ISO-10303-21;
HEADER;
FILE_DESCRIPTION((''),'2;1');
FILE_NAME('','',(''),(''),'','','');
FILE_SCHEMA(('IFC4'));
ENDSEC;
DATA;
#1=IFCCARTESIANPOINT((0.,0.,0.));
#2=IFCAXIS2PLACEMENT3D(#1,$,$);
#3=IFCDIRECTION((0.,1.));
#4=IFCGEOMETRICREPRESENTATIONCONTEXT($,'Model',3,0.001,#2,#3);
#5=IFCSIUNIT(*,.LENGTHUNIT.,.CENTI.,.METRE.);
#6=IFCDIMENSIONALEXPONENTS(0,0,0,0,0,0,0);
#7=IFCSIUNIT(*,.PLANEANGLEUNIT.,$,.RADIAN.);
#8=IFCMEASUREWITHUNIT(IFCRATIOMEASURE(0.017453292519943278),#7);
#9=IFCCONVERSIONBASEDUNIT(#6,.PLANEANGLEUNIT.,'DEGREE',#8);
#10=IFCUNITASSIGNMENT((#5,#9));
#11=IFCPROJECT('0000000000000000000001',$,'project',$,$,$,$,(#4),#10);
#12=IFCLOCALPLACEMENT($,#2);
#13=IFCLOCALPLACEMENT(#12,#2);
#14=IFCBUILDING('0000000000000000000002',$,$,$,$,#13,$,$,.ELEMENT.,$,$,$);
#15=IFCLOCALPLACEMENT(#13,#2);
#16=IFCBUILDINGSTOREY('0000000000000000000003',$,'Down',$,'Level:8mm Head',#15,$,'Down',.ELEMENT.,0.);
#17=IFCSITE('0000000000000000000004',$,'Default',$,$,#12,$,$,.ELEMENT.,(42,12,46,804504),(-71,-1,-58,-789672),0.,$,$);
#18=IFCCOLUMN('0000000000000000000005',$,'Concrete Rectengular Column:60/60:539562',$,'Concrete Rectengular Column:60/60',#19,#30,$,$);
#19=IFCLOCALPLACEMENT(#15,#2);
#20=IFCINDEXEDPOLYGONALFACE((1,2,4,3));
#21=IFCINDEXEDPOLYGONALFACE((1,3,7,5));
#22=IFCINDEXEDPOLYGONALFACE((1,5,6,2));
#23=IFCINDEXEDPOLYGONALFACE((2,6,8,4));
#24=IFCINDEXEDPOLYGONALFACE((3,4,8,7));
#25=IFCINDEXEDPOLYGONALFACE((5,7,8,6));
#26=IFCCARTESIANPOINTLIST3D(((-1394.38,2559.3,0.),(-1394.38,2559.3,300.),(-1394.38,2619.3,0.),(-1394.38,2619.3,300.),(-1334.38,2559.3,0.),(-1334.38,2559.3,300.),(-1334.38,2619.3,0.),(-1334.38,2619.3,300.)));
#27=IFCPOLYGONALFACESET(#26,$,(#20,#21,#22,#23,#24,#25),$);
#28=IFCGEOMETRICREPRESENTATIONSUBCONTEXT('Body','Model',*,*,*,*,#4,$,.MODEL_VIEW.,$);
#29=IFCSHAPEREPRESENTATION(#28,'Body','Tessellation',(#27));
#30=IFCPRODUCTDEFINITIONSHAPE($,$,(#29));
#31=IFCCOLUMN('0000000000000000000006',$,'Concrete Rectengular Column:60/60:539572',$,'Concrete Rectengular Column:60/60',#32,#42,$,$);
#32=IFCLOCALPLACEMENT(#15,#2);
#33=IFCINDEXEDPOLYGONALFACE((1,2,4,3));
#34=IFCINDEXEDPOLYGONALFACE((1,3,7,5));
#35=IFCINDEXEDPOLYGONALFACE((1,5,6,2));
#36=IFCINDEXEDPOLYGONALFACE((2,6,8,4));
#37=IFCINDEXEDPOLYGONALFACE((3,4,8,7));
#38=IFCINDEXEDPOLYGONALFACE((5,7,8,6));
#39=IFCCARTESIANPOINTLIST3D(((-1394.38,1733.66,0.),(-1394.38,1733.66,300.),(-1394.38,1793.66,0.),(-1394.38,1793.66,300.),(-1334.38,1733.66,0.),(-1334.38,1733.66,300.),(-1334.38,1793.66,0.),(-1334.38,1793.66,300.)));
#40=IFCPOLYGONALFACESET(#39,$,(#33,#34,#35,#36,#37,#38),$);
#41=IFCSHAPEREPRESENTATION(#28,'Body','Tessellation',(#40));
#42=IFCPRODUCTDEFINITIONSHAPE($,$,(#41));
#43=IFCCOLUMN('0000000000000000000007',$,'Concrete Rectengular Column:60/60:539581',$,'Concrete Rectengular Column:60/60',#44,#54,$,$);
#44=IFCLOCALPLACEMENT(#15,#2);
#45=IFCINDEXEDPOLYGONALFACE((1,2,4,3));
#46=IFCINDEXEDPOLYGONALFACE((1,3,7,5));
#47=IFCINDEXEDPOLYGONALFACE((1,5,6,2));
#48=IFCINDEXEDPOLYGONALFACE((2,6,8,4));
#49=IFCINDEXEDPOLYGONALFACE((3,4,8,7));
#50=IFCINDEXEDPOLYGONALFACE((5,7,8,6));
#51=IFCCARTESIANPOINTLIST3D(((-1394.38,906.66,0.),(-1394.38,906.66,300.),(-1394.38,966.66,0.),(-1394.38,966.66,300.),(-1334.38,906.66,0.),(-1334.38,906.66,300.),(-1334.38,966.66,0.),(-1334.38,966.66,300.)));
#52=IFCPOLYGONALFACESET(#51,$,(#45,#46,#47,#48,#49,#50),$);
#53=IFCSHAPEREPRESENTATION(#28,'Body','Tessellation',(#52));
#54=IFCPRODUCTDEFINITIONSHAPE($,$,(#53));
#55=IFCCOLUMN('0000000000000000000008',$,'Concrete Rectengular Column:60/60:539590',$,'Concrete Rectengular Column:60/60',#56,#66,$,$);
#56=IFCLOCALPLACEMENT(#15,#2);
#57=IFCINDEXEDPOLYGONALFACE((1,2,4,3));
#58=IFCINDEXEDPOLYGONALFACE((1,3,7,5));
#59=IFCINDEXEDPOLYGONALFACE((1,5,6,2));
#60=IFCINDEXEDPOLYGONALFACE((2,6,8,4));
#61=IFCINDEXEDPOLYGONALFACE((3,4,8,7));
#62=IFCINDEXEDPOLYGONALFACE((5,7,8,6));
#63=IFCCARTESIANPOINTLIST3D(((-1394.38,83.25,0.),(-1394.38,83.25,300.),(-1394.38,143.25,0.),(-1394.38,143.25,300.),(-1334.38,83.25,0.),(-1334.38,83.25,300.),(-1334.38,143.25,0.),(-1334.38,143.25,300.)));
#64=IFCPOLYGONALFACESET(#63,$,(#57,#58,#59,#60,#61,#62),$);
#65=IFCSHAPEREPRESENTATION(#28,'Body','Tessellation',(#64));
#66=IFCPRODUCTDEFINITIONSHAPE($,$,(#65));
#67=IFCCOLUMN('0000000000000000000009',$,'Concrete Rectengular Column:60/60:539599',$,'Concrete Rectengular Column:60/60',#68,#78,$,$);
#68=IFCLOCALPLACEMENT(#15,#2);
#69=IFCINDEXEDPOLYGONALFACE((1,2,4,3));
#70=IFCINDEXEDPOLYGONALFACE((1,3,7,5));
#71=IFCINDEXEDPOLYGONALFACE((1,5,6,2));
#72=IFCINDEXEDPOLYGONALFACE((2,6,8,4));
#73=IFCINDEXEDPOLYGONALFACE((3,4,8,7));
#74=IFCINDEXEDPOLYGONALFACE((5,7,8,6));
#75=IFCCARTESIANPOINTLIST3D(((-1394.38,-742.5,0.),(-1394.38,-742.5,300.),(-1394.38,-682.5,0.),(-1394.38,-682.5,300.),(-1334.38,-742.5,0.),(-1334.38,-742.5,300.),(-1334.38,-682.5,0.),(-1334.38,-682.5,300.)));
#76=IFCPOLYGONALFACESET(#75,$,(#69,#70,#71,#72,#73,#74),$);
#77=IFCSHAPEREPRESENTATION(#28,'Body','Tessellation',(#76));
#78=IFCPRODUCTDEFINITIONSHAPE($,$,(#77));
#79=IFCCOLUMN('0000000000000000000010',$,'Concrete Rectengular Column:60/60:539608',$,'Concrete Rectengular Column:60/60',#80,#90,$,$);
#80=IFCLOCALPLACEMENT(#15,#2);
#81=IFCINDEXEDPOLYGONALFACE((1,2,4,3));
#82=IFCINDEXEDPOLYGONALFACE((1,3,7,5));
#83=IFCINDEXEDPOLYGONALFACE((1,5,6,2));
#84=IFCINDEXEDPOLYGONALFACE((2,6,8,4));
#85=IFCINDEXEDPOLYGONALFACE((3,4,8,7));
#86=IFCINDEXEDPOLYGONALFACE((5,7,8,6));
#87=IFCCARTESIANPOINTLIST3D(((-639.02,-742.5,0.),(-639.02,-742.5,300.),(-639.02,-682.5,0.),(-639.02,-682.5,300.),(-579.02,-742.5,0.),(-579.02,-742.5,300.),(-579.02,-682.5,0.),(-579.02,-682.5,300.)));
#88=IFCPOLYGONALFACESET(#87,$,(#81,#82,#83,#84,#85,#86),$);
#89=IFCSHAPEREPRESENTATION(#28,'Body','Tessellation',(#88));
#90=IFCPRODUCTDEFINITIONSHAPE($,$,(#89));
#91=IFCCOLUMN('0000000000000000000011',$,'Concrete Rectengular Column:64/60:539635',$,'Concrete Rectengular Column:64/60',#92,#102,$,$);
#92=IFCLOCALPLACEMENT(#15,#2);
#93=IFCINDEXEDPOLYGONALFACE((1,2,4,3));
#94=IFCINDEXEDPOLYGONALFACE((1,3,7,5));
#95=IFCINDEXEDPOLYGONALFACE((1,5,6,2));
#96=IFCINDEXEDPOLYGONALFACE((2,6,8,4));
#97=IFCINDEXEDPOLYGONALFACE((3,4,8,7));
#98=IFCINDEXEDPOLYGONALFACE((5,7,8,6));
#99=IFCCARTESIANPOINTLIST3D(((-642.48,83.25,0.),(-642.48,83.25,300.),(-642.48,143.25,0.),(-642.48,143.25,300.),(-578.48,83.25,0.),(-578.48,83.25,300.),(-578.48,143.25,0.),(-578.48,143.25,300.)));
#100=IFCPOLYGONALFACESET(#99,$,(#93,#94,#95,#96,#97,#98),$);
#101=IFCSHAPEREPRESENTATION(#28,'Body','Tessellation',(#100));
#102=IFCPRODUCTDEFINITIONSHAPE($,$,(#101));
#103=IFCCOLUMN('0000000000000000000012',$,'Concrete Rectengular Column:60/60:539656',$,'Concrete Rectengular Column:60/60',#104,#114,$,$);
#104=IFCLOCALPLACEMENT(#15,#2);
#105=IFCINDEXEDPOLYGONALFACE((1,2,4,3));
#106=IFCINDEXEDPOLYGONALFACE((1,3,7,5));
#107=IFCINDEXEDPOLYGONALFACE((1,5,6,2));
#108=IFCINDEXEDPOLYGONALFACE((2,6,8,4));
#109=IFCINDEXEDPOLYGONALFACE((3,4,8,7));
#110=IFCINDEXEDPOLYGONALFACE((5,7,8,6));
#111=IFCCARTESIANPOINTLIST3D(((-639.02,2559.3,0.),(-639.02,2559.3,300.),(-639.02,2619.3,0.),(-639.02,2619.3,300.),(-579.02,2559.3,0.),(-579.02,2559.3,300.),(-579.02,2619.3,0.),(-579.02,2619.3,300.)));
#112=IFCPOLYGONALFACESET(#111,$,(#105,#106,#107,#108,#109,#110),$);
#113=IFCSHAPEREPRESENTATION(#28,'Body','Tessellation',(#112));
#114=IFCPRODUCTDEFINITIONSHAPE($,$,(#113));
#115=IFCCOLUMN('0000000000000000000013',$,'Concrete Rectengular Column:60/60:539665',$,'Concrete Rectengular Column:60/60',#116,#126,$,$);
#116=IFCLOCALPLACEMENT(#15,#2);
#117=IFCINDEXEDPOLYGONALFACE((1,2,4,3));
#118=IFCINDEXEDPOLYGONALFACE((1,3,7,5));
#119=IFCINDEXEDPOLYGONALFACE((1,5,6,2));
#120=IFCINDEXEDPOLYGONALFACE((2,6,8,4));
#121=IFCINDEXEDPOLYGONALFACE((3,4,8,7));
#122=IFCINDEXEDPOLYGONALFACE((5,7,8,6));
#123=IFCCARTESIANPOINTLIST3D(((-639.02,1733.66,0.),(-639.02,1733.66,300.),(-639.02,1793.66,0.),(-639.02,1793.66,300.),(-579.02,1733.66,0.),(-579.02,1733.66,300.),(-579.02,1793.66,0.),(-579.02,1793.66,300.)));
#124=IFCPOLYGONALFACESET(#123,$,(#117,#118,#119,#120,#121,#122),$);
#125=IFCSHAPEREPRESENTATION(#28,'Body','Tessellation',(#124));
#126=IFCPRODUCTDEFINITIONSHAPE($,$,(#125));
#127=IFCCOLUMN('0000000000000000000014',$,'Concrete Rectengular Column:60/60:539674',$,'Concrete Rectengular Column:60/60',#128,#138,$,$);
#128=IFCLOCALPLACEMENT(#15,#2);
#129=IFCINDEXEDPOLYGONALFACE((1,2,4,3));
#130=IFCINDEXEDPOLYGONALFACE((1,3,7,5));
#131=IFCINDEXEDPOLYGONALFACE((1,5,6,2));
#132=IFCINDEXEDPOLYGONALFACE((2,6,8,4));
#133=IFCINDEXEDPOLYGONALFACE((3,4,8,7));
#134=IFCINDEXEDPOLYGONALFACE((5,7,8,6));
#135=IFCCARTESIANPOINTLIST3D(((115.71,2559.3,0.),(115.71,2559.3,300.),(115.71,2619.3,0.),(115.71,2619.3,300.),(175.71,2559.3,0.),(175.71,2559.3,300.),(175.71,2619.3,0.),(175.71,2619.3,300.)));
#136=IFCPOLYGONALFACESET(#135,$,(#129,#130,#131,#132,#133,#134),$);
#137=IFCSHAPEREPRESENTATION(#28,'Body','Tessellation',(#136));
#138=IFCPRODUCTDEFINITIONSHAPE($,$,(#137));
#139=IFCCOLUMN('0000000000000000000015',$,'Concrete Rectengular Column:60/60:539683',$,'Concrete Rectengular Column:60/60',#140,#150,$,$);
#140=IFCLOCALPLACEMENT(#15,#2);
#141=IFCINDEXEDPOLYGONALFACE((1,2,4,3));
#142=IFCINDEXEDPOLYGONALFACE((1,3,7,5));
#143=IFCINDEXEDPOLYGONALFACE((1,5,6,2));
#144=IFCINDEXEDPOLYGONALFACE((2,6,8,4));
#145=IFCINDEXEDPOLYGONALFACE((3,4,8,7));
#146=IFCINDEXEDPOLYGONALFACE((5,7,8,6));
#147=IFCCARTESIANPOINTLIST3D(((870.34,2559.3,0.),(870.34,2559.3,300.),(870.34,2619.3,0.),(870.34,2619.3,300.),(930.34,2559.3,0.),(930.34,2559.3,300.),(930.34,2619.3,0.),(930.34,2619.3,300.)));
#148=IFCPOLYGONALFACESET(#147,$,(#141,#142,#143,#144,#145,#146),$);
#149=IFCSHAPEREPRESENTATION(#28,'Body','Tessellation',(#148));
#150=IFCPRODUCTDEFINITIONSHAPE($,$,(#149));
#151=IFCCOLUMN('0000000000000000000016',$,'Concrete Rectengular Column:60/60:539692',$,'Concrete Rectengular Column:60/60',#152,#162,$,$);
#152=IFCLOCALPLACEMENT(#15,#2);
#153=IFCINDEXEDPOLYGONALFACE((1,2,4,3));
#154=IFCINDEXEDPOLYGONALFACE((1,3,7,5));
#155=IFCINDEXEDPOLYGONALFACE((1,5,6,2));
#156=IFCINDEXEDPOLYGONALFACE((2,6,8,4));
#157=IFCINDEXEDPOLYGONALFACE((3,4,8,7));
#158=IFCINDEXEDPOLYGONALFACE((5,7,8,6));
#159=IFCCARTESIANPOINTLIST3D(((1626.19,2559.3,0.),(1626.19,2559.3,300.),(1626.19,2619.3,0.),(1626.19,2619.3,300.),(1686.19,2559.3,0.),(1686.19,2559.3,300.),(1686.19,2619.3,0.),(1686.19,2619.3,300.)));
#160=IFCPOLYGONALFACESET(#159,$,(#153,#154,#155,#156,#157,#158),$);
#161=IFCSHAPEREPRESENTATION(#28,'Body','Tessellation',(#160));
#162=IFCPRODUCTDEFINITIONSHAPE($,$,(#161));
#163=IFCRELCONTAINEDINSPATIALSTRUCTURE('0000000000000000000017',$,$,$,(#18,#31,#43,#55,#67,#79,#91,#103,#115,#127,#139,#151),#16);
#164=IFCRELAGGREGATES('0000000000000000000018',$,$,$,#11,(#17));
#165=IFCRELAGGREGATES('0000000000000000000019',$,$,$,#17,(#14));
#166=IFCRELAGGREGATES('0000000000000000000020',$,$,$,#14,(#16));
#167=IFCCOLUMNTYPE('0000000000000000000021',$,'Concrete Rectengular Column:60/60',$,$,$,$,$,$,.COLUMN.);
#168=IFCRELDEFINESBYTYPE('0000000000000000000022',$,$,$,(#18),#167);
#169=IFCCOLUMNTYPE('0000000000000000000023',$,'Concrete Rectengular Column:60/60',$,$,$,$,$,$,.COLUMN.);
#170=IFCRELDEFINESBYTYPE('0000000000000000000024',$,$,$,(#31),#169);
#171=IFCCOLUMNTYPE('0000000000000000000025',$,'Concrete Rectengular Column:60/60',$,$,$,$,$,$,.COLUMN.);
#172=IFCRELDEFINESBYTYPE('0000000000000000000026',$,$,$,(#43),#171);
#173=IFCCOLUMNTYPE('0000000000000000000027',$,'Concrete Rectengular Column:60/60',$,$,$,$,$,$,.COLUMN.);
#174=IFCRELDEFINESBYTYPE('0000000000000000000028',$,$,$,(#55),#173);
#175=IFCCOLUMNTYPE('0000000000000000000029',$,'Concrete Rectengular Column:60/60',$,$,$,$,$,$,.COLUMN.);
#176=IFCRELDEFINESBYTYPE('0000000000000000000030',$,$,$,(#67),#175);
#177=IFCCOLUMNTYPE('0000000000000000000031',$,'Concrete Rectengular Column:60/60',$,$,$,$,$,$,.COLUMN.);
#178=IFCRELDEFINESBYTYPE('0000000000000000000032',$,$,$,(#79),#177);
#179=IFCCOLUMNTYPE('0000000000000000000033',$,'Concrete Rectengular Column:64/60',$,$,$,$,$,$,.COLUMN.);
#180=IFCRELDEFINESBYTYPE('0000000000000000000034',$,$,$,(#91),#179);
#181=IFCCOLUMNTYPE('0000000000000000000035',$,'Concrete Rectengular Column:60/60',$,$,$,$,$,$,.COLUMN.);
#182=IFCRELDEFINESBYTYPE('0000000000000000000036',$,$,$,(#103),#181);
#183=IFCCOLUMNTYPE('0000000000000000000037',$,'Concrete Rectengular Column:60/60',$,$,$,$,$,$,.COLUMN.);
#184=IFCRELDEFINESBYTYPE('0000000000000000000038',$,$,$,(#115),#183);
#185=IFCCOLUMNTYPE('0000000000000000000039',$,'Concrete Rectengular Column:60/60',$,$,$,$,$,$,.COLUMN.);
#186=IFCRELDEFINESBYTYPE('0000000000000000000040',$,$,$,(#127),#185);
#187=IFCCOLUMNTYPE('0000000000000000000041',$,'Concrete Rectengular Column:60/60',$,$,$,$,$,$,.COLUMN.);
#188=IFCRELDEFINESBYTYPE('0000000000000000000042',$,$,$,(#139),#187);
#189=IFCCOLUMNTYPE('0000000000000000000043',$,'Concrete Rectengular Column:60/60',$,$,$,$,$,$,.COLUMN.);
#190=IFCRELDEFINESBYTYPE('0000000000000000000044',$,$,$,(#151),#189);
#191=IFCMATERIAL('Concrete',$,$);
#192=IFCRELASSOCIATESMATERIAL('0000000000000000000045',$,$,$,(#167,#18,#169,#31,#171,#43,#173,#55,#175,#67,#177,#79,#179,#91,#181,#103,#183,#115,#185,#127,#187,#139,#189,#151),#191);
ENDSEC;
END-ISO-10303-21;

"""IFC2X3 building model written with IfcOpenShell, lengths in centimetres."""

from ifc_helpers import new_model, entity, si_unit, converted_unit, direction, frame, frame_2d, origin, origin_2d_with_axis, place, context, subcontext, project, spatial, rectangle, extrude, source, transform, mapped, material, type_object, type_shapes, element, save


model = new_model("IFC2X3")

# Units and contexts
model_context = context("Model", 3, precision=0.001, world=origin(), true_north=direction((0.0, 1.0)))
body_context = subcontext(model_context, "Body", "Model", "MODEL_VIEW")
ifc_project = project(units=[si_unit("LENGTHUNIT", "METRE", prefix="CENTI"), converted_unit("PLANEANGLEUNIT", "DEGREE", entity("IfcRatioMeasure", 0.017453292519943278), si_unit("PLANEANGLEUNIT", "RADIAN"), dimensions=[0, 0, 0, 0, 0, 0, 0])], contexts=[model_context])

# Site, building, storey
site_placement = place(None, origin())
site = spatial("IfcSite", under=ifc_project, at=site_placement, Name="Default", CompositionType="ELEMENT", RefLatitude=(42, 12, 46, 804504), RefLongitude=(-71, -1, -58, -789672), RefElevation=0.0)
building_placement = place(site_placement, origin())
building = spatial("IfcBuilding", under=site, at=building_placement, CompositionType="ELEMENT")
storey_placement = place(building_placement, origin())
storey = spatial("IfcBuildingStorey", under=building, at=storey_placement, Name="Down", ObjectType="Level:8mm Head", LongName="Down", CompositionType="ELEMENT", Elevation=0.0)

# Columns
ifc_material = material(Name="Concrete")
column_type_1 = type_object("IfcColumnType", Name="Concrete Rectengular Column:60/60", PredefinedType="COLUMN", material=ifc_material)
shared_shape_1 = source(origin(), body_context, "Body", "SweptSolid", [
    extrude(rectangle(XDim=60.0, YDim=60.0, at=frame_2d((0.0, 0.0), x_axis=(1.0, 0.0))), frame((-1364.38, 2589.3, 0.0), z_axis=(0.0, 0.0, 1.0), x_axis=(0.0, -1.0, 0.0)), (0.0, 0.0, 1.0), 300.0),
])
type_shapes(column_type_1, [shared_shape_1])
column_1_placement = place(storey_placement, origin())
element("IfcColumn", 1, at=column_1_placement, inside=storey, type_object=column_type_1, material=ifc_material, Name="Concrete Rectengular Column:60/60:539562", ObjectType="Concrete Rectengular Column:60/60", context=body_context, shape_type="MappedRepresentation", body=[
    mapped(shared_shape_1, transform((0.0, 0.0, 0.0), scale=1.0)),
])
column_type_2 = type_object("IfcColumnType", Name="Concrete Rectengular Column:60/60", PredefinedType="COLUMN", material=ifc_material)
shared_shape_2 = source(origin(), body_context, "Body", "SweptSolid", [
    extrude(rectangle(XDim=60.0, YDim=60.0, at=frame_2d((0.0, 0.0), x_axis=(1.0, 0.0))), frame((-1364.38, 1763.66, 0.0), z_axis=(0.0, 0.0, 1.0), x_axis=(0.0, -1.0, 0.0)), (0.0, 0.0, 1.0), 300.0),
])
type_shapes(column_type_2, [shared_shape_2])
column_2_placement = place(storey_placement, origin())
element("IfcColumn", 2, at=column_2_placement, inside=storey, type_object=column_type_2, material=ifc_material, Name="Concrete Rectengular Column:60/60:539572", ObjectType="Concrete Rectengular Column:60/60", context=body_context, shape_type="MappedRepresentation", body=[
    mapped(shared_shape_2, transform((0.0, 0.0, 0.0), scale=1.0)),
])
column_type_3 = type_object("IfcColumnType", Name="Concrete Rectengular Column:60/60", PredefinedType="COLUMN", material=ifc_material)
shared_shape_3 = source(origin(), body_context, "Body", "SweptSolid", [
    extrude(rectangle(XDim=60.0, YDim=60.0, at=frame_2d((0.0, 0.0), x_axis=(1.0, 0.0))), frame((-1364.38, 936.66, 0.0), z_axis=(0.0, 0.0, 1.0), x_axis=(0.0, -1.0, 0.0)), (0.0, 0.0, 1.0), 300.0),
])
type_shapes(column_type_3, [shared_shape_3])
column_3_placement = place(storey_placement, origin())
element("IfcColumn", 3, at=column_3_placement, inside=storey, type_object=column_type_3, material=ifc_material, Name="Concrete Rectengular Column:60/60:539581", ObjectType="Concrete Rectengular Column:60/60", context=body_context, shape_type="MappedRepresentation", body=[
    mapped(shared_shape_3, transform((0.0, 0.0, 0.0), scale=1.0)),
])
column_type_4 = type_object("IfcColumnType", Name="Concrete Rectengular Column:60/60", PredefinedType="COLUMN", material=ifc_material)
shared_shape_4 = source(origin(), body_context, "Body", "SweptSolid", [
    extrude(rectangle(XDim=60.0, YDim=60.0, at=frame_2d((0.0, 0.0), x_axis=(1.0, 0.0))), frame((-1364.38, 113.25, 0.0), z_axis=(0.0, 0.0, 1.0), x_axis=(0.0, -1.0, 0.0)), (0.0, 0.0, 1.0), 300.0),
])
type_shapes(column_type_4, [shared_shape_4])
column_4_placement = place(storey_placement, origin())
element("IfcColumn", 4, at=column_4_placement, inside=storey, type_object=column_type_4, material=ifc_material, Name="Concrete Rectengular Column:60/60:539590", ObjectType="Concrete Rectengular Column:60/60", context=body_context, shape_type="MappedRepresentation", body=[
    mapped(shared_shape_4, transform((0.0, 0.0, 0.0), scale=1.0)),
])
column_type_5 = type_object("IfcColumnType", Name="Concrete Rectengular Column:60/60", PredefinedType="COLUMN", material=ifc_material)
shared_shape_5 = source(origin(), body_context, "Body", "SweptSolid", [
    extrude(rectangle(XDim=60.0, YDim=60.0, at=frame_2d((0.0, 0.0), x_axis=(1.0, 0.0))), frame((-1364.38, -712.5, 0.0), z_axis=(0.0, 0.0, 1.0), x_axis=(0.0, -1.0, 0.0)), (0.0, 0.0, 1.0), 300.0),
])
type_shapes(column_type_5, [shared_shape_5])
column_5_placement = place(storey_placement, origin())
element("IfcColumn", 5, at=column_5_placement, inside=storey, type_object=column_type_5, material=ifc_material, Name="Concrete Rectengular Column:60/60:539599", ObjectType="Concrete Rectengular Column:60/60", context=body_context, shape_type="MappedRepresentation", body=[
    mapped(shared_shape_5, transform((0.0, 0.0, 0.0), scale=1.0)),
])
column_type_6 = type_object("IfcColumnType", Name="Concrete Rectengular Column:60/60", PredefinedType="COLUMN", material=ifc_material)
shared_shape_6 = source(origin(), body_context, "Body", "SweptSolid", [
    extrude(rectangle(XDim=60.0, YDim=60.0, at=origin_2d_with_axis()), frame((-609.02, -712.5, 0.0), z_axis=(0.0, 0.0, 1.0), x_axis=(0.0, -1.0, 0.0)), (0.0, 0.0, 1.0), 300.0),
])
type_shapes(column_type_6, [shared_shape_6])
column_6_placement = place(storey_placement, origin())
element("IfcColumn", 6, at=column_6_placement, inside=storey, type_object=column_type_6, material=ifc_material, Name="Concrete Rectengular Column:60/60:539608", ObjectType="Concrete Rectengular Column:60/60", context=body_context, shape_type="MappedRepresentation", body=[
    mapped(shared_shape_6, transform((0.0, 0.0, 0.0), scale=1.0)),
])
column_type_7 = type_object("IfcColumnType", Name="Concrete Rectengular Column:64/60", PredefinedType="COLUMN", material=ifc_material)
shared_shape_7 = source(origin(), body_context, "Body", "SweptSolid", [
    extrude(rectangle(XDim=60.0, YDim=64.0, at=origin_2d_with_axis()), frame((-610.48, 113.25, 0.0), z_axis=(0.0, 0.0, 1.0), x_axis=(0.0, -1.0, 0.0)), (0.0, 0.0, 1.0), 300.0),
])
type_shapes(column_type_7, [shared_shape_7])
column_7_placement = place(storey_placement, origin())
element("IfcColumn", 7, at=column_7_placement, inside=storey, type_object=column_type_7, material=ifc_material, Name="Concrete Rectengular Column:64/60:539635", ObjectType="Concrete Rectengular Column:64/60", context=body_context, shape_type="MappedRepresentation", body=[
    mapped(shared_shape_7, transform((0.0, 0.0, 0.0), scale=1.0)),
])
column_type_8 = type_object("IfcColumnType", Name="Concrete Rectengular Column:60/60", PredefinedType="COLUMN", material=ifc_material)
shared_shape_8 = source(origin(), body_context, "Body", "SweptSolid", [
    extrude(rectangle(XDim=60.0, YDim=60.0, at=origin_2d_with_axis()), frame((-609.02, 2589.3, 0.0), z_axis=(0.0, 0.0, 1.0), x_axis=(0.0, -1.0, 0.0)), (0.0, 0.0, 1.0), 300.0),
])
type_shapes(column_type_8, [shared_shape_8])
column_8_placement = place(storey_placement, origin())
element("IfcColumn", 8, at=column_8_placement, inside=storey, type_object=column_type_8, material=ifc_material, Name="Concrete Rectengular Column:60/60:539656", ObjectType="Concrete Rectengular Column:60/60", context=body_context, shape_type="MappedRepresentation", body=[
    mapped(shared_shape_8, transform((0.0, 0.0, 0.0), scale=1.0)),
])
column_type_9 = type_object("IfcColumnType", Name="Concrete Rectengular Column:60/60", PredefinedType="COLUMN", material=ifc_material)
shared_shape_9 = source(origin(), body_context, "Body", "SweptSolid", [
    extrude(rectangle(XDim=60.0, YDim=60.0, at=frame_2d((0.0, 0.0), x_axis=(1.0, 0.0))), frame((-609.02, 1763.66, 0.0), z_axis=(0.0, 0.0, 1.0), x_axis=(0.0, -1.0, 0.0)), (0.0, 0.0, 1.0), 300.0),
])
type_shapes(column_type_9, [shared_shape_9])
column_9_placement = place(storey_placement, origin())
element("IfcColumn", 9, at=column_9_placement, inside=storey, type_object=column_type_9, material=ifc_material, Name="Concrete Rectengular Column:60/60:539665", ObjectType="Concrete Rectengular Column:60/60", context=body_context, shape_type="MappedRepresentation", body=[
    mapped(shared_shape_9, transform((0.0, 0.0, 0.0), scale=1.0)),
])
column_type_10 = type_object("IfcColumnType", Name="Concrete Rectengular Column:60/60", PredefinedType="COLUMN", material=ifc_material)
shared_shape_10 = source(origin(), body_context, "Body", "SweptSolid", [
    extrude(rectangle(XDim=60.0, YDim=60.0, at=origin_2d_with_axis()), frame((145.71, 2589.3, 0.0), z_axis=(0.0, 0.0, 1.0), x_axis=(0.0, -1.0, 0.0)), (0.0, 0.0, 1.0), 300.0),
])
type_shapes(column_type_10, [shared_shape_10])
column_10_placement = place(storey_placement, origin())
element("IfcColumn", 10, at=column_10_placement, inside=storey, type_object=column_type_10, material=ifc_material, Name="Concrete Rectengular Column:60/60:539674", ObjectType="Concrete Rectengular Column:60/60", context=body_context, shape_type="MappedRepresentation", body=[
    mapped(shared_shape_10, transform((0.0, 0.0, 0.0), scale=1.0)),
])
column_type_11 = type_object("IfcColumnType", Name="Concrete Rectengular Column:60/60", PredefinedType="COLUMN", material=ifc_material)
shared_shape_11 = source(origin(), body_context, "Body", "SweptSolid", [
    extrude(rectangle(XDim=60.0, YDim=60.0, at=frame_2d((0.0, 0.0), x_axis=(1.0, 0.0))), frame((900.34, 2589.3, 0.0), z_axis=(0.0, 0.0, 1.0), x_axis=(0.0, -1.0, 0.0)), (0.0, 0.0, 1.0), 300.0),
])
type_shapes(column_type_11, [shared_shape_11])
column_11_placement = place(storey_placement, origin())
element("IfcColumn", 11, at=column_11_placement, inside=storey, type_object=column_type_11, material=ifc_material, Name="Concrete Rectengular Column:60/60:539683", ObjectType="Concrete Rectengular Column:60/60", context=body_context, shape_type="MappedRepresentation", body=[
    mapped(shared_shape_11, transform((0.0, 0.0, 0.0), scale=1.0)),
])
column_type_12 = type_object("IfcColumnType", Name="Concrete Rectengular Column:60/60", PredefinedType="COLUMN", material=ifc_material)
shared_shape_12 = source(origin(), body_context, "Body", "SweptSolid", [
    extrude(rectangle(XDim=60.0, YDim=60.0, at=frame_2d((0.0, 0.0), x_axis=(1.0, 0.0))), frame((1656.19, 2589.3, 0.0), z_axis=(0.0, 0.0, 1.0), x_axis=(0.0, -1.0, 0.0)), (0.0, 0.0, 1.0), 300.0),
])
type_shapes(column_type_12, [shared_shape_12])
column_12_placement = place(storey_placement, origin())
element("IfcColumn", 12, at=column_12_placement, inside=storey, type_object=column_type_12, material=ifc_material, Name="Concrete Rectengular Column:60/60:539692", ObjectType="Concrete Rectengular Column:60/60", context=body_context, shape_type="MappedRepresentation", body=[
    mapped(shared_shape_12, transform((0.0, 0.0, 0.0), scale=1.0)),
])

save(model, "model.ifc")
